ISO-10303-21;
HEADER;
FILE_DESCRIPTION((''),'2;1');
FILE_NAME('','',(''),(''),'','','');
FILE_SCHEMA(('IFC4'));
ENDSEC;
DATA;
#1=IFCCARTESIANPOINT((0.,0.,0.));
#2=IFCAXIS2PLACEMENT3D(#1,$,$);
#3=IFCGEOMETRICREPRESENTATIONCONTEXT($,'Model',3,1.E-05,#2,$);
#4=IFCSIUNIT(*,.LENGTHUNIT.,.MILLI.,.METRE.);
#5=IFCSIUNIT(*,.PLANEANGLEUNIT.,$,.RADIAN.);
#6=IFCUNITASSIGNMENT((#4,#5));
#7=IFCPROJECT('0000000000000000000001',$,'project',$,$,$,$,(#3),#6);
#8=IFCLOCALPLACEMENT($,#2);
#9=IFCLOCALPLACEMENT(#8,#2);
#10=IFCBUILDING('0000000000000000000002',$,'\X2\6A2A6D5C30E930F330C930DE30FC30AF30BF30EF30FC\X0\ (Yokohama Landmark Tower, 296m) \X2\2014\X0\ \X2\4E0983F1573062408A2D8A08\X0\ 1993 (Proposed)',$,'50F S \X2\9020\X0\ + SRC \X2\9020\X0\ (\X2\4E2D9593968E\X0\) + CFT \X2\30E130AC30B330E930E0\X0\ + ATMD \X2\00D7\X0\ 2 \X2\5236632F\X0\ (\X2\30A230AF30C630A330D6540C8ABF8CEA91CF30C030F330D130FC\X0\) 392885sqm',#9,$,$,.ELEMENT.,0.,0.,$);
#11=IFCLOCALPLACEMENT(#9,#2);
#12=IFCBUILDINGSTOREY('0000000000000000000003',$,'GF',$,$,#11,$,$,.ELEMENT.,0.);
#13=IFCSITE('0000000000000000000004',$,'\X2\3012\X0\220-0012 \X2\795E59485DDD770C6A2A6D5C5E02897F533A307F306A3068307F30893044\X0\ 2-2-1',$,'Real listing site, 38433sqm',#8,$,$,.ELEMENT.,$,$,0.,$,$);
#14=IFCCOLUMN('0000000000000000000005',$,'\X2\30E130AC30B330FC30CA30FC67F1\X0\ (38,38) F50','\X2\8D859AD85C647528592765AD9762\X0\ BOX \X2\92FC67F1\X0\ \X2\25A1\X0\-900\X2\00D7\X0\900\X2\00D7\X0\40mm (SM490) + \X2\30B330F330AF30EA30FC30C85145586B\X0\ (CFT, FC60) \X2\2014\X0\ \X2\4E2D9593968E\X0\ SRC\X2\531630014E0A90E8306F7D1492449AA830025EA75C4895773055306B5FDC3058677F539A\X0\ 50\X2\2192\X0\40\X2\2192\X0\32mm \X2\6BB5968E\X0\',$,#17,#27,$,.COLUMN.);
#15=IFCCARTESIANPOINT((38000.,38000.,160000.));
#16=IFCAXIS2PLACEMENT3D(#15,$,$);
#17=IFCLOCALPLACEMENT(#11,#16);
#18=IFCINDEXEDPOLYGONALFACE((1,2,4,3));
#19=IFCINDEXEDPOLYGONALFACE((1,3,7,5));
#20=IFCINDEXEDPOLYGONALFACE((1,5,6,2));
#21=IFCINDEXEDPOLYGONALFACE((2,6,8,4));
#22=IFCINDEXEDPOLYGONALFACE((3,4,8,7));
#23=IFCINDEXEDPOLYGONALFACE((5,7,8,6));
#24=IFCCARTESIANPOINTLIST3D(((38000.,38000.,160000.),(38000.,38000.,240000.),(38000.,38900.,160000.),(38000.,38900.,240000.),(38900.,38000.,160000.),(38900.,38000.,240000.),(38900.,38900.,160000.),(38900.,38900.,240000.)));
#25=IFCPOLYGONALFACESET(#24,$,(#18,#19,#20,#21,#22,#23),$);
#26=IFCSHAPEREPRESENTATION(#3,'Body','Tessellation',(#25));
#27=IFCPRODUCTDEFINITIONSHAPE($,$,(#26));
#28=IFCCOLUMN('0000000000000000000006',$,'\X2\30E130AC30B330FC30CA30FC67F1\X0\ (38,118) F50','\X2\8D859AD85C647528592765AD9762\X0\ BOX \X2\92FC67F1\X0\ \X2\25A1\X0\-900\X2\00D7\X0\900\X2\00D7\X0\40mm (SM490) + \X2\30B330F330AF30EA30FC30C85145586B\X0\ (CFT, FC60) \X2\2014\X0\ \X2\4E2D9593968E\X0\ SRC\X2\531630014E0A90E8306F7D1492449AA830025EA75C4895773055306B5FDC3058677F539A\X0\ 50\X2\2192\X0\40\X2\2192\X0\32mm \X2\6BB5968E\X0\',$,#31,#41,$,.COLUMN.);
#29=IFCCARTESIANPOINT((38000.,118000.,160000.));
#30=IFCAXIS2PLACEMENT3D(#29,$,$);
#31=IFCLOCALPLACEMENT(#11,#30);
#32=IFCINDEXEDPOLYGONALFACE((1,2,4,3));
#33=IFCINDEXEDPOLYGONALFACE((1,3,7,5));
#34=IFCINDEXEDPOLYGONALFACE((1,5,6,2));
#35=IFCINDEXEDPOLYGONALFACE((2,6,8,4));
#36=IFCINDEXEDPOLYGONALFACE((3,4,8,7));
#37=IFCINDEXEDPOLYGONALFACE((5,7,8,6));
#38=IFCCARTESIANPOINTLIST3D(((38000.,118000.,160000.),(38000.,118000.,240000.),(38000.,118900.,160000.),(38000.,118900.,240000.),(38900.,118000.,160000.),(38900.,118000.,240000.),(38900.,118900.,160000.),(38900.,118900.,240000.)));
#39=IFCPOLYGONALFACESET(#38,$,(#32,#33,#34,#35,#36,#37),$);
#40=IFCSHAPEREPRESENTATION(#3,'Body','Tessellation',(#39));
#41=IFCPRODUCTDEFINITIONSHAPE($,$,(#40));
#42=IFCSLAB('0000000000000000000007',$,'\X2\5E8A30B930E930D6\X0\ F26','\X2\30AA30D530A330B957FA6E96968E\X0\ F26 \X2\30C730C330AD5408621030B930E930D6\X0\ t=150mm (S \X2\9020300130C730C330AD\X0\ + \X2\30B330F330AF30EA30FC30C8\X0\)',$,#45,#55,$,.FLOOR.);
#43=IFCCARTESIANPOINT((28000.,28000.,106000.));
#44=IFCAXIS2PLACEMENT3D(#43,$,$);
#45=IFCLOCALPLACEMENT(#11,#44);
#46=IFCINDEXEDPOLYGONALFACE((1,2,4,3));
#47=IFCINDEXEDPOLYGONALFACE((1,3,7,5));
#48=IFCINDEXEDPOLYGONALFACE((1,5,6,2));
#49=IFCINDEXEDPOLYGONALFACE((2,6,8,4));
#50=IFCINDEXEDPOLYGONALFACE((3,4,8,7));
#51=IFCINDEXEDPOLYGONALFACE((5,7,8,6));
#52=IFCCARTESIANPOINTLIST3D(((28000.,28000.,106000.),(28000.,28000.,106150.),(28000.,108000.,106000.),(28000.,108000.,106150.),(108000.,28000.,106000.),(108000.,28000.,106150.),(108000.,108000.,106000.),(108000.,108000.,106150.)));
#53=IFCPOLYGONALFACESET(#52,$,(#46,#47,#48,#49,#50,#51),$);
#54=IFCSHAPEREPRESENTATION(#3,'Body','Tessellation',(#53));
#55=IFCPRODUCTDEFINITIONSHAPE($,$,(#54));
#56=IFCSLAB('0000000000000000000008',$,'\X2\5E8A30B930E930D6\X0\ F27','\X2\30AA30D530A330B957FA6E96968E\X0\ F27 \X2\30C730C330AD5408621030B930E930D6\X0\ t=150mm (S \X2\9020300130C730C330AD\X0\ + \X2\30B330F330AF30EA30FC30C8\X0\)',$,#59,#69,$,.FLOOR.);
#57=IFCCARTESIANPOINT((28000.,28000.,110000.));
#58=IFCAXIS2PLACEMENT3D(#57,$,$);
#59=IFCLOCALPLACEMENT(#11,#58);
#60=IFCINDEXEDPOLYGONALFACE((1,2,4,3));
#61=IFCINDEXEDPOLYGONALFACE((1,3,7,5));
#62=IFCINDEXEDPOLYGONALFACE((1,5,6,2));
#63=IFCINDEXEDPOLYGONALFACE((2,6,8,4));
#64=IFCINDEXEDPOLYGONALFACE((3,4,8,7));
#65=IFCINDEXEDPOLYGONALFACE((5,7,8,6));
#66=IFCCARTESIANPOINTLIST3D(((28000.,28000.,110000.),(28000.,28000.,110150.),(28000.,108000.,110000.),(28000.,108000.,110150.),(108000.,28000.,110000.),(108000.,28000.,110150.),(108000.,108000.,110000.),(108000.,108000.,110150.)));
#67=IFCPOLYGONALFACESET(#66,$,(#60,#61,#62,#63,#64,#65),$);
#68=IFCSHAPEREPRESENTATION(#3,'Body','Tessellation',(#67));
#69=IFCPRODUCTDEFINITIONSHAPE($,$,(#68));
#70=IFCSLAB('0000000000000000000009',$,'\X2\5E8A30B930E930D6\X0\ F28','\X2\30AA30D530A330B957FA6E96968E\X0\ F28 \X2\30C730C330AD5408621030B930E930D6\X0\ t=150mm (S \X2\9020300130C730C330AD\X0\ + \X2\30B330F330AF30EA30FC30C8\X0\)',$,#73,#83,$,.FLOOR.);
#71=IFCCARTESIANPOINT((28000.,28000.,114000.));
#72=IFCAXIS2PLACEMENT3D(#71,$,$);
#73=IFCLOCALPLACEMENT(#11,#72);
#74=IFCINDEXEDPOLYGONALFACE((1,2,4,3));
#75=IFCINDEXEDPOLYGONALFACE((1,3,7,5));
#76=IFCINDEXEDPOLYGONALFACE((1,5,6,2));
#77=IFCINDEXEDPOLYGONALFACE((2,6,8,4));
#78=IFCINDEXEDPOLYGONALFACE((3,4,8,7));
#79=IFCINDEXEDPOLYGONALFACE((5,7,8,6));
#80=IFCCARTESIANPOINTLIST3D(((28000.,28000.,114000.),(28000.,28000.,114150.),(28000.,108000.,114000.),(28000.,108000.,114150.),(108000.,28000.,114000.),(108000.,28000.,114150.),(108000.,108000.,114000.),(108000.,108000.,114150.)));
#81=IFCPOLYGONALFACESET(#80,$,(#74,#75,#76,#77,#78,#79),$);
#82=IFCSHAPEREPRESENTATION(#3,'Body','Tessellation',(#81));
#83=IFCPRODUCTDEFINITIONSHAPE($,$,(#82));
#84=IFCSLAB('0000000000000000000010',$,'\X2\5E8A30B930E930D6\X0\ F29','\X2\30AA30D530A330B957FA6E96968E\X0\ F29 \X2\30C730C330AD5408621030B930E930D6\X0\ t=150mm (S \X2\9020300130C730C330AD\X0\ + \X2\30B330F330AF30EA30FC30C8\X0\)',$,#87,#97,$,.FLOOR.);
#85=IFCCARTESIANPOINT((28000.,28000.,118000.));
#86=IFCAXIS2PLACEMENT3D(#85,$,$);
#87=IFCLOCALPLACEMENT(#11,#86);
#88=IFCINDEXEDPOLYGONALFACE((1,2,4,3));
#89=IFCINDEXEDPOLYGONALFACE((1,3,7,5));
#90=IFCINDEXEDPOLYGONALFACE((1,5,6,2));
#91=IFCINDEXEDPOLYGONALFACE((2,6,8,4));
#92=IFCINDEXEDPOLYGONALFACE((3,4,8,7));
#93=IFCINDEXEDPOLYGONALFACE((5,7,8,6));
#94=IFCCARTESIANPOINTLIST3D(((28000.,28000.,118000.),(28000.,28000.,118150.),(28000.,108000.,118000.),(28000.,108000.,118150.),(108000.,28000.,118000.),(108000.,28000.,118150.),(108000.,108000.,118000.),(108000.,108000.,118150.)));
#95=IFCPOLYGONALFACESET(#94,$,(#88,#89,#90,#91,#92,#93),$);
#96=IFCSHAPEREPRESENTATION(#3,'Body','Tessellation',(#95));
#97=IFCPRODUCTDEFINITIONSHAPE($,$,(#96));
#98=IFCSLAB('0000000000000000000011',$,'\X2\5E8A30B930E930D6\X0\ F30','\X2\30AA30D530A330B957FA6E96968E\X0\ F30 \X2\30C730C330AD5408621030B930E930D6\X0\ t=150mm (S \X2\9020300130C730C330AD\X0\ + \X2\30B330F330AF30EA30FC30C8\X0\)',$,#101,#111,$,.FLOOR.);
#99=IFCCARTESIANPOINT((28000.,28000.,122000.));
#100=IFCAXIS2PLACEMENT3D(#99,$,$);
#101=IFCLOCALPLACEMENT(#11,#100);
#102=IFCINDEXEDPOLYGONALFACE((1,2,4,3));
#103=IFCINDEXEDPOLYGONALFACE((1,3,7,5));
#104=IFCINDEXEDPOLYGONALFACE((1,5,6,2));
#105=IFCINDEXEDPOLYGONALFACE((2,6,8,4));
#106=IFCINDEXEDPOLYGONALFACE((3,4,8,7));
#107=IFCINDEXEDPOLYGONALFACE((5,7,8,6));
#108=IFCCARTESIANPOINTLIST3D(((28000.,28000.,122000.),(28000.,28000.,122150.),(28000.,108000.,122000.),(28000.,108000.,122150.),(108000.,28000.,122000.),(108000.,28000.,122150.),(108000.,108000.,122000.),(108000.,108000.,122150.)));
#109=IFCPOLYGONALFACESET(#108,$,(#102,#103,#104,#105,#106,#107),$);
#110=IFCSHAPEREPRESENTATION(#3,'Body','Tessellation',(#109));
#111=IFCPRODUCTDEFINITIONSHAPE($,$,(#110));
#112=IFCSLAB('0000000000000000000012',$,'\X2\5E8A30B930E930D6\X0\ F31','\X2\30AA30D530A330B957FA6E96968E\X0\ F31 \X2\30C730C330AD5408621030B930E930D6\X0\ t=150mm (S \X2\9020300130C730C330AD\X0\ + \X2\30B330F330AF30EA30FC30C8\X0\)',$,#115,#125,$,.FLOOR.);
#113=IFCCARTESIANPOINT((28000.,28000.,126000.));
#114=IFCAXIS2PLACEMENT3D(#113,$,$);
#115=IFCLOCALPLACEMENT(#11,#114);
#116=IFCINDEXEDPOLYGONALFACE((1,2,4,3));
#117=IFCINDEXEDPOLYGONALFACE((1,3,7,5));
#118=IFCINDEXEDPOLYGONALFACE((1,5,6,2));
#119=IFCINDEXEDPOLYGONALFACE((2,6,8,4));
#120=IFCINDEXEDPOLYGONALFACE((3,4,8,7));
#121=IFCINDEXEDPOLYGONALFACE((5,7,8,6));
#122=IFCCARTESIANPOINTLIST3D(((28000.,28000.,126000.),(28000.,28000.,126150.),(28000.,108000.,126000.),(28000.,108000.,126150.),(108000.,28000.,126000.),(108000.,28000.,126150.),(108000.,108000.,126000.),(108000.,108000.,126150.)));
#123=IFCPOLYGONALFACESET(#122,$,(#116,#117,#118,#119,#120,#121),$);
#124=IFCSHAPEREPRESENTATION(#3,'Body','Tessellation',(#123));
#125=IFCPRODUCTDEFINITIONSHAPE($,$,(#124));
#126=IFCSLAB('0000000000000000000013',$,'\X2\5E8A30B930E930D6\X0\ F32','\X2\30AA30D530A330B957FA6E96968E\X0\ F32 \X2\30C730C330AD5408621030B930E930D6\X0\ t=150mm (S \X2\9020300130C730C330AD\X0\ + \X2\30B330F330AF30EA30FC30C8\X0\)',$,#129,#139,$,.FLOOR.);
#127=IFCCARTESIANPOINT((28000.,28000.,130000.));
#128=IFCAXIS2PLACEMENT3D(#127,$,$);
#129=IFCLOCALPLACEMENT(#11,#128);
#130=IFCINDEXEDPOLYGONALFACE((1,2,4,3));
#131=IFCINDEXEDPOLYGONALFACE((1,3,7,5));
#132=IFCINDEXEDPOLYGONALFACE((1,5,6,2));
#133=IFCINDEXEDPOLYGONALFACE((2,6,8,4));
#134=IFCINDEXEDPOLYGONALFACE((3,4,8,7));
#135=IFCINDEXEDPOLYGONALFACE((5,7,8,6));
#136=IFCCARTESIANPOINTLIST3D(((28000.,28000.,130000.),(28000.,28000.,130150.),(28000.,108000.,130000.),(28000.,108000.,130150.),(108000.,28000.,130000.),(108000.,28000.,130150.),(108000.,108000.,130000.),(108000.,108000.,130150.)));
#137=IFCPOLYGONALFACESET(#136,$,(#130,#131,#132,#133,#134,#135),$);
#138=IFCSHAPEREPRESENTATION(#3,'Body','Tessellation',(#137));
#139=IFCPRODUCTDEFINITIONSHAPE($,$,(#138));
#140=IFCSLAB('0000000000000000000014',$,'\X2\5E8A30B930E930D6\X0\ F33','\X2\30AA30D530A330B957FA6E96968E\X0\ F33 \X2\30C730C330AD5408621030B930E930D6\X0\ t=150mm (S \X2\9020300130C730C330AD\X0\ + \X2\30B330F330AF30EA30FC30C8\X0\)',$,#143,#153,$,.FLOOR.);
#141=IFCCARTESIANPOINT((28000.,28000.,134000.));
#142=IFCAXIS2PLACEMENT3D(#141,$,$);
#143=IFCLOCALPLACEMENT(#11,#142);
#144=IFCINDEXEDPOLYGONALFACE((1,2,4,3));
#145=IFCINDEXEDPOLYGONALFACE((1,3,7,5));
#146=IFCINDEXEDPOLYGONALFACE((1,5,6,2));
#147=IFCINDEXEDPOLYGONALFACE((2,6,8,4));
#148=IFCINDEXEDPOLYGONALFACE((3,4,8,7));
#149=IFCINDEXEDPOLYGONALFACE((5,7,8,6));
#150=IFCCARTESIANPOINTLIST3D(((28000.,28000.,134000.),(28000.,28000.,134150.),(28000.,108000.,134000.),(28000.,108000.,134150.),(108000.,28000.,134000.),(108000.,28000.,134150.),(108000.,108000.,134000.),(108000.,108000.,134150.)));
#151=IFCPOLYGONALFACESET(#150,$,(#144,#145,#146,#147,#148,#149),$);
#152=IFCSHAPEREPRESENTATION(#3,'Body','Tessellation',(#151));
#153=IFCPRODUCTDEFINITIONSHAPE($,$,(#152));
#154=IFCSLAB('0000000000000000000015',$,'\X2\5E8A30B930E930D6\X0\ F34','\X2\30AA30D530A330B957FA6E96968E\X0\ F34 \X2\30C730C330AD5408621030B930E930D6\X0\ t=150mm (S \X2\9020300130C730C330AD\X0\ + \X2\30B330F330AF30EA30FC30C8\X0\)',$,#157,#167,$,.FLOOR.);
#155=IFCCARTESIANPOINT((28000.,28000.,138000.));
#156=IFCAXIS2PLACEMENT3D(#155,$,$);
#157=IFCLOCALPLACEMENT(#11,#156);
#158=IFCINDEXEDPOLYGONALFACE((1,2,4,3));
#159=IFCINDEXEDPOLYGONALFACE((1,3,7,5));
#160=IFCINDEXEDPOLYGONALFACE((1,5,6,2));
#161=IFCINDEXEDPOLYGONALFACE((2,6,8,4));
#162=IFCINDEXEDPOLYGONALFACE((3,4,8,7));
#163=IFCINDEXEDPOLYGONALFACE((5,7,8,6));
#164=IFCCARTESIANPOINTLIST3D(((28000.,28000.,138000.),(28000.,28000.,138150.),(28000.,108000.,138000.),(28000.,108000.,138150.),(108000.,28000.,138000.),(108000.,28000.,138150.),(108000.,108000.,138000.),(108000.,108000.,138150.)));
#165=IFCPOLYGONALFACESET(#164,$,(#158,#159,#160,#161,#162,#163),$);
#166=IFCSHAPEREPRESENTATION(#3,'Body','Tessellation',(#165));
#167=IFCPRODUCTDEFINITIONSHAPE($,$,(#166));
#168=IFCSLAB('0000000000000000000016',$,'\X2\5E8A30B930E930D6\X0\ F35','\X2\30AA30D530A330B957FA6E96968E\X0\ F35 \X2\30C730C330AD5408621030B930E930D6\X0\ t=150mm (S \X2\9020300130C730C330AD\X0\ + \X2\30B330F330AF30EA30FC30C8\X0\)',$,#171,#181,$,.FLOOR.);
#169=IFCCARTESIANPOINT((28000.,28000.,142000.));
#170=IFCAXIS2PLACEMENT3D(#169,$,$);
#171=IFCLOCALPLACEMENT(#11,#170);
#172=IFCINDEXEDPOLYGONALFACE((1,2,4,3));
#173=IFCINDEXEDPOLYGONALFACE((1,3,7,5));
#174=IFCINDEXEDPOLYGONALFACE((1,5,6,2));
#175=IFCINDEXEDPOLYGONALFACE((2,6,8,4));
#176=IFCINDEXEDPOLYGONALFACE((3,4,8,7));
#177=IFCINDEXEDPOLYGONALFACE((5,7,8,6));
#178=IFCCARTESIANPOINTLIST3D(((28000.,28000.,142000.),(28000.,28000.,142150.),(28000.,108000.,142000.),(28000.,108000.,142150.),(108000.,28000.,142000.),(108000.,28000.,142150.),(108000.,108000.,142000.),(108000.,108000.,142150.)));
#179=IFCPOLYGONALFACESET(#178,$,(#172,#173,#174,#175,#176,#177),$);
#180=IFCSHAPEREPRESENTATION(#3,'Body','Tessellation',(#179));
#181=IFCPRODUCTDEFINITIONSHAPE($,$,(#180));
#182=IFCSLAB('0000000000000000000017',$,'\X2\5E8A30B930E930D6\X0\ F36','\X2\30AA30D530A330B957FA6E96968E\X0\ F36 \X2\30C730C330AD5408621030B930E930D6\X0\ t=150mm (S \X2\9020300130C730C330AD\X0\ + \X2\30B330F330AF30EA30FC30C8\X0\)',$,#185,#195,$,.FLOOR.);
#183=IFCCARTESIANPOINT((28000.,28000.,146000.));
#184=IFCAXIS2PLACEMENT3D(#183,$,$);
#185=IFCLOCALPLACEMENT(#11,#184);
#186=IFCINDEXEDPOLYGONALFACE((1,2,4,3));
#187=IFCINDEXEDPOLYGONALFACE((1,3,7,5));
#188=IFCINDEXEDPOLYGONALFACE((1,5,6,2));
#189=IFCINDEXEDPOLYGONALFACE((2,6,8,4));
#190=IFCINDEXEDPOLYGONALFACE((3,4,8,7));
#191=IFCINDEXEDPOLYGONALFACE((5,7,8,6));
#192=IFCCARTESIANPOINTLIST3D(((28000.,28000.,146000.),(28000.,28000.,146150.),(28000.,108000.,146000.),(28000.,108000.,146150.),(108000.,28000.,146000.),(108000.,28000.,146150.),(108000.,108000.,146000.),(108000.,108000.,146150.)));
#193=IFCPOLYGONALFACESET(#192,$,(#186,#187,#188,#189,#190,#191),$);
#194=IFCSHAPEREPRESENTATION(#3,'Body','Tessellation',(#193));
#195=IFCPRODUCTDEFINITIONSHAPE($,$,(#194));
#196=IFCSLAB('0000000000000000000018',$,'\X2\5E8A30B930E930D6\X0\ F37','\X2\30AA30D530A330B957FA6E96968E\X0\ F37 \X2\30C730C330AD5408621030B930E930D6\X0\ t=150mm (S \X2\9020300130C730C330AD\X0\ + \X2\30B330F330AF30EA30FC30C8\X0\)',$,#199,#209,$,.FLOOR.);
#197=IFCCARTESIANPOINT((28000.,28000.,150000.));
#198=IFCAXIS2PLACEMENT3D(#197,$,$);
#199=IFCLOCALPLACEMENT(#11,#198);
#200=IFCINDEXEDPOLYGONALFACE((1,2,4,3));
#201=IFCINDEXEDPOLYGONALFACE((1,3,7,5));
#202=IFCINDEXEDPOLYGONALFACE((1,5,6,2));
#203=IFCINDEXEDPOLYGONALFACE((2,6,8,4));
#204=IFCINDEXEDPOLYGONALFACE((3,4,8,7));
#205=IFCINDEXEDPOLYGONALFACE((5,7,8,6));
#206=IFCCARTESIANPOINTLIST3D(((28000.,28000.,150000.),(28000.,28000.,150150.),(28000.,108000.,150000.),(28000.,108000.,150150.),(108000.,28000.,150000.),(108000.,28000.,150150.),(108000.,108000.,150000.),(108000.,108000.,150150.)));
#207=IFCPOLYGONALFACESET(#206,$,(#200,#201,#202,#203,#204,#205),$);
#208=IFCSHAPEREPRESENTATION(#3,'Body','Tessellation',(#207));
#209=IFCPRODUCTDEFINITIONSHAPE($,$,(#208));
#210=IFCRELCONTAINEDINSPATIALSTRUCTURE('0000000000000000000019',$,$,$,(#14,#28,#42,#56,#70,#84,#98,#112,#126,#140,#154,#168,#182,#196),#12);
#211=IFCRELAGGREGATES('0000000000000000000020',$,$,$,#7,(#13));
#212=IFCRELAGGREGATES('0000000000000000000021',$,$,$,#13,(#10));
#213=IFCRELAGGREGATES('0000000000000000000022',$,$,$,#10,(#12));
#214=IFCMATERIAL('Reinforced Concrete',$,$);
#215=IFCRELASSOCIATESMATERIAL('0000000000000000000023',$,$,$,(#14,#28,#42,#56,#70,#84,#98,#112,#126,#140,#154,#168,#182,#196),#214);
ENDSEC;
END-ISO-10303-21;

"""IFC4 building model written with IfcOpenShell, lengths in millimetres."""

from ifc_helpers import new_model, si_unit, frame, frame_2d, origin, place, context, project, spatial, rectangle, extrude, material, element, save


model = new_model("IFC4")

# Units and contexts
model_context = context("Model", 3, precision=1e-05, world=origin())
ifc_project = project(units=[si_unit("LENGTHUNIT", "METRE", prefix="MILLI"), si_unit("PLANEANGLEUNIT", "RADIAN")], contexts=[model_context])

# Site, building, storey
site_placement = place(None, origin())
site = spatial("IfcSite", under=ifc_project, at=site_placement, Name="〒220-0012 神奈川県横浜市西区みなとみらい 2-2-1", ObjectType="Real listing site, 38433sqm", CompositionType="ELEMENT", RefElevation=0.0)
building_placement = place(site_placement, origin())
building = spatial("IfcBuilding", under=site, at=building_placement, Name="横浜ランドマークタワー (Yokohama Landmark Tower, 296m) — 三菱地所設計 1993 (Proposed)", ObjectType="50F S 造 + SRC 造 (中間階) + CFT メガコラム + ATMD × 2 制振 (アクティブ同調質量ダンパー) 392885sqm", CompositionType="ELEMENT", ElevationOfRefHeight=0.0, ElevationOfTerrain=0.0)
storey_placement = place(building_placement, origin())
storey = spatial("IfcBuildingStorey", under=building, at=storey_placement, Name="GF", CompositionType="ELEMENT", Elevation=0.0)

# Columns
ifc_material_1 = material(Name="Reinforced Concrete")
column_1_placement = place(storey_placement, frame((38000.0, 38000.0, 160000.0)))
element("IfcColumn", 1, at=column_1_placement, inside=storey, material=ifc_material_1, Name="メガコーナー柱 (38,38) F50", Description="超高層用大断面 BOX 鋼柱 □-900×900×40mm (SM490) + コンクリート充填 (CFT, FC60) — 中間階 SRC化、上部は純鉄骨。座屈長さに応じ板厚 50→40→32mm 段階", PredefinedType="COLUMN", context=model_context, shape_type="SweptSolid", body=[
    extrude(rectangle(XDim=900.0, YDim=900.0, at=frame_2d((450.0, 450.0))), frame((38000.0, 38000.0, 160000.0)), (0.0, 0.0, 1.0), 80000.0),
])
column_2_placement = place(storey_placement, frame((38000.0, 118000.0, 160000.0)))
element("IfcColumn", 2, at=column_2_placement, inside=storey, material=ifc_material_1, Name="メガコーナー柱 (38,118) F50", Description="超高層用大断面 BOX 鋼柱 □-900×900×40mm (SM490) + コンクリート充填 (CFT, FC60) — 中間階 SRC化、上部は純鉄骨。座屈長さに応じ板厚 50→40→32mm 段階", PredefinedType="COLUMN", context=model_context, shape_type="SweptSolid", body=[
    extrude(rectangle(XDim=900.0, YDim=900.0, at=frame_2d((450.0, 450.0))), frame((38000.0, 118000.0, 160000.0)), (0.0, 0.0, 1.0), 80000.0),
])

# Slabs
slab_1_placement = place(storey_placement, frame((28000.0, 28000.0, 106000.0)))
element("IfcSlab", 3, at=slab_1_placement, inside=storey, material=ifc_material_1, Name="床スラブ F26", Description="オフィス基準階 F26 デッキ合成スラブ t=150mm (S 造、デッキ + コンクリート)", PredefinedType="FLOOR", context=model_context, shape_type="SweptSolid", body=[
    extrude(rectangle(XDim=80000.0, YDim=80000.0, at=frame_2d((40000.0, 40000.0))), frame((28000.0, 28000.0, 106000.0)), (0.0, 0.0, 1.0), 150.0),
])
slab_2_placement = place(storey_placement, frame((28000.0, 28000.0, 110000.0)))
element("IfcSlab", 4, at=slab_2_placement, inside=storey, material=ifc_material_1, Name="床スラブ F27", Description="オフィス基準階 F27 デッキ合成スラブ t=150mm (S 造、デッキ + コンクリート)", PredefinedType="FLOOR", context=model_context, shape_type="SweptSolid", body=[
    extrude(rectangle(XDim=80000.0, YDim=80000.0, at=frame_2d((40000.0, 40000.0))), frame((28000.0, 28000.0, 110000.0)), (0.0, 0.0, 1.0), 150.0),
])
slab_3_placement = place(storey_placement, frame((28000.0, 28000.0, 114000.0)))
element("IfcSlab", 5, at=slab_3_placement, inside=storey, material=ifc_material_1, Name="床スラブ F28", Description="オフィス基準階 F28 デッキ合成スラブ t=150mm (S 造、デッキ + コンクリート)", PredefinedType="FLOOR", context=model_context, shape_type="SweptSolid", body=[
    extrude(rectangle(XDim=80000.0, YDim=80000.0, at=frame_2d((40000.0, 40000.0))), frame((28000.0, 28000.0, 114000.0)), (0.0, 0.0, 1.0), 150.0),
])
slab_4_placement = place(storey_placement, frame((28000.0, 28000.0, 118000.0)))
element("IfcSlab", 6, at=slab_4_placement, inside=storey, material=ifc_material_1, Name="床スラブ F29", Description="オフィス基準階 F29 デッキ合成スラブ t=150mm (S 造、デッキ + コンクリート)", PredefinedType="FLOOR", context=model_context, shape_type="SweptSolid", body=[
    extrude(rectangle(XDim=80000.0, YDim=80000.0, at=frame_2d((40000.0, 40000.0))), frame((28000.0, 28000.0, 118000.0)), (0.0, 0.0, 1.0), 150.0),
])
slab_5_placement = place(storey_placement, frame((28000.0, 28000.0, 122000.0)))
element("IfcSlab", 7, at=slab_5_placement, inside=storey, material=ifc_material_1, Name="床スラブ F30", Description="オフィス基準階 F30 デッキ合成スラブ t=150mm (S 造、デッキ + コンクリート)", PredefinedType="FLOOR", context=model_context, shape_type="SweptSolid", body=[
    extrude(rectangle(XDim=80000.0, YDim=80000.0, at=frame_2d((40000.0, 40000.0))), frame((28000.0, 28000.0, 122000.0)), (0.0, 0.0, 1.0), 150.0),
])
slab_6_placement = place(storey_placement, frame((28000.0, 28000.0, 126000.0)))
element("IfcSlab", 8, at=slab_6_placement, inside=storey, material=ifc_material_1, Name="床スラブ F31", Description="オフィス基準階 F31 デッキ合成スラブ t=150mm (S 造、デッキ + コンクリート)", PredefinedType="FLOOR", context=model_context, shape_type="SweptSolid", body=[
    extrude(rectangle(XDim=80000.0, YDim=80000.0, at=frame_2d((40000.0, 40000.0))), frame((28000.0, 28000.0, 126000.0)), (0.0, 0.0, 1.0), 150.0),
])
slab_7_placement = place(storey_placement, frame((28000.0, 28000.0, 130000.0)))
element("IfcSlab", 9, at=slab_7_placement, inside=storey, material=ifc_material_1, Name="床スラブ F32", Description="オフィス基準階 F32 デッキ合成スラブ t=150mm (S 造、デッキ + コンクリート)", PredefinedType="FLOOR", context=model_context, shape_type="SweptSolid", body=[
    extrude(rectangle(XDim=80000.0, YDim=80000.0, at=frame_2d((40000.0, 40000.0))), frame((28000.0, 28000.0, 130000.0)), (0.0, 0.0, 1.0), 150.0),
])
slab_8_placement = place(storey_placement, frame((28000.0, 28000.0, 134000.0)))
element("IfcSlab", 10, at=slab_8_placement, inside=storey, material=ifc_material_1, Name="床スラブ F33", Description="オフィス基準階 F33 デッキ合成スラブ t=150mm (S 造、デッキ + コンクリート)", PredefinedType="FLOOR", context=model_context, shape_type="SweptSolid", body=[
    extrude(rectangle(XDim=80000.0, YDim=80000.0, at=frame_2d((40000.0, 40000.0))), frame((28000.0, 28000.0, 134000.0)), (0.0, 0.0, 1.0), 150.0),
])
slab_9_placement = place(storey_placement, frame((28000.0, 28000.0, 138000.0)))
element("IfcSlab", 11, at=slab_9_placement, inside=storey, material=ifc_material_1, Name="床スラブ F34", Description="オフィス基準階 F34 デッキ合成スラブ t=150mm (S 造、デッキ + コンクリート)", PredefinedType="FLOOR", context=model_context, shape_type="SweptSolid", body=[
    extrude(rectangle(XDim=80000.0, YDim=80000.0, at=frame_2d((40000.0, 40000.0))), frame((28000.0, 28000.0, 138000.0)), (0.0, 0.0, 1.0), 150.0),
])
slab_10_placement = place(storey_placement, frame((28000.0, 28000.0, 142000.0)))
element("IfcSlab", 12, at=slab_10_placement, inside=storey, material=ifc_material_1, Name="床スラブ F35", Description="オフィス基準階 F35 デッキ合成スラブ t=150mm (S 造、デッキ + コンクリート)", PredefinedType="FLOOR", context=model_context, shape_type="SweptSolid", body=[
    extrude(rectangle(XDim=80000.0, YDim=80000.0, at=frame_2d((40000.0, 40000.0))), frame((28000.0, 28000.0, 142000.0)), (0.0, 0.0, 1.0), 150.0),
])
slab_11_placement = place(storey_placement, frame((28000.0, 28000.0, 146000.0)))
element("IfcSlab", 13, at=slab_11_placement, inside=storey, material=ifc_material_1, Name="床スラブ F36", Description="オフィス基準階 F36 デッキ合成スラブ t=150mm (S 造、デッキ + コンクリート)", PredefinedType="FLOOR", context=model_context, shape_type="SweptSolid", body=[
    extrude(rectangle(XDim=80000.0, YDim=80000.0, at=frame_2d((40000.0, 40000.0))), frame((28000.0, 28000.0, 146000.0)), (0.0, 0.0, 1.0), 150.0),
])
slab_12_placement = place(storey_placement, frame((28000.0, 28000.0, 150000.0)))
element("IfcSlab", 14, at=slab_12_placement, inside=storey, material=ifc_material_1, Name="床スラブ F37", Description="オフィス基準階 F37 デッキ合成スラブ t=150mm (S 造、デッキ + コンクリート)", PredefinedType="FLOOR", context=model_context, shape_type="SweptSolid", body=[
    extrude(rectangle(XDim=80000.0, YDim=80000.0, at=frame_2d((40000.0, 40000.0))), frame((28000.0, 28000.0, 150000.0)), (0.0, 0.0, 1.0), 150.0),
])

save(model, "model.ifc")
